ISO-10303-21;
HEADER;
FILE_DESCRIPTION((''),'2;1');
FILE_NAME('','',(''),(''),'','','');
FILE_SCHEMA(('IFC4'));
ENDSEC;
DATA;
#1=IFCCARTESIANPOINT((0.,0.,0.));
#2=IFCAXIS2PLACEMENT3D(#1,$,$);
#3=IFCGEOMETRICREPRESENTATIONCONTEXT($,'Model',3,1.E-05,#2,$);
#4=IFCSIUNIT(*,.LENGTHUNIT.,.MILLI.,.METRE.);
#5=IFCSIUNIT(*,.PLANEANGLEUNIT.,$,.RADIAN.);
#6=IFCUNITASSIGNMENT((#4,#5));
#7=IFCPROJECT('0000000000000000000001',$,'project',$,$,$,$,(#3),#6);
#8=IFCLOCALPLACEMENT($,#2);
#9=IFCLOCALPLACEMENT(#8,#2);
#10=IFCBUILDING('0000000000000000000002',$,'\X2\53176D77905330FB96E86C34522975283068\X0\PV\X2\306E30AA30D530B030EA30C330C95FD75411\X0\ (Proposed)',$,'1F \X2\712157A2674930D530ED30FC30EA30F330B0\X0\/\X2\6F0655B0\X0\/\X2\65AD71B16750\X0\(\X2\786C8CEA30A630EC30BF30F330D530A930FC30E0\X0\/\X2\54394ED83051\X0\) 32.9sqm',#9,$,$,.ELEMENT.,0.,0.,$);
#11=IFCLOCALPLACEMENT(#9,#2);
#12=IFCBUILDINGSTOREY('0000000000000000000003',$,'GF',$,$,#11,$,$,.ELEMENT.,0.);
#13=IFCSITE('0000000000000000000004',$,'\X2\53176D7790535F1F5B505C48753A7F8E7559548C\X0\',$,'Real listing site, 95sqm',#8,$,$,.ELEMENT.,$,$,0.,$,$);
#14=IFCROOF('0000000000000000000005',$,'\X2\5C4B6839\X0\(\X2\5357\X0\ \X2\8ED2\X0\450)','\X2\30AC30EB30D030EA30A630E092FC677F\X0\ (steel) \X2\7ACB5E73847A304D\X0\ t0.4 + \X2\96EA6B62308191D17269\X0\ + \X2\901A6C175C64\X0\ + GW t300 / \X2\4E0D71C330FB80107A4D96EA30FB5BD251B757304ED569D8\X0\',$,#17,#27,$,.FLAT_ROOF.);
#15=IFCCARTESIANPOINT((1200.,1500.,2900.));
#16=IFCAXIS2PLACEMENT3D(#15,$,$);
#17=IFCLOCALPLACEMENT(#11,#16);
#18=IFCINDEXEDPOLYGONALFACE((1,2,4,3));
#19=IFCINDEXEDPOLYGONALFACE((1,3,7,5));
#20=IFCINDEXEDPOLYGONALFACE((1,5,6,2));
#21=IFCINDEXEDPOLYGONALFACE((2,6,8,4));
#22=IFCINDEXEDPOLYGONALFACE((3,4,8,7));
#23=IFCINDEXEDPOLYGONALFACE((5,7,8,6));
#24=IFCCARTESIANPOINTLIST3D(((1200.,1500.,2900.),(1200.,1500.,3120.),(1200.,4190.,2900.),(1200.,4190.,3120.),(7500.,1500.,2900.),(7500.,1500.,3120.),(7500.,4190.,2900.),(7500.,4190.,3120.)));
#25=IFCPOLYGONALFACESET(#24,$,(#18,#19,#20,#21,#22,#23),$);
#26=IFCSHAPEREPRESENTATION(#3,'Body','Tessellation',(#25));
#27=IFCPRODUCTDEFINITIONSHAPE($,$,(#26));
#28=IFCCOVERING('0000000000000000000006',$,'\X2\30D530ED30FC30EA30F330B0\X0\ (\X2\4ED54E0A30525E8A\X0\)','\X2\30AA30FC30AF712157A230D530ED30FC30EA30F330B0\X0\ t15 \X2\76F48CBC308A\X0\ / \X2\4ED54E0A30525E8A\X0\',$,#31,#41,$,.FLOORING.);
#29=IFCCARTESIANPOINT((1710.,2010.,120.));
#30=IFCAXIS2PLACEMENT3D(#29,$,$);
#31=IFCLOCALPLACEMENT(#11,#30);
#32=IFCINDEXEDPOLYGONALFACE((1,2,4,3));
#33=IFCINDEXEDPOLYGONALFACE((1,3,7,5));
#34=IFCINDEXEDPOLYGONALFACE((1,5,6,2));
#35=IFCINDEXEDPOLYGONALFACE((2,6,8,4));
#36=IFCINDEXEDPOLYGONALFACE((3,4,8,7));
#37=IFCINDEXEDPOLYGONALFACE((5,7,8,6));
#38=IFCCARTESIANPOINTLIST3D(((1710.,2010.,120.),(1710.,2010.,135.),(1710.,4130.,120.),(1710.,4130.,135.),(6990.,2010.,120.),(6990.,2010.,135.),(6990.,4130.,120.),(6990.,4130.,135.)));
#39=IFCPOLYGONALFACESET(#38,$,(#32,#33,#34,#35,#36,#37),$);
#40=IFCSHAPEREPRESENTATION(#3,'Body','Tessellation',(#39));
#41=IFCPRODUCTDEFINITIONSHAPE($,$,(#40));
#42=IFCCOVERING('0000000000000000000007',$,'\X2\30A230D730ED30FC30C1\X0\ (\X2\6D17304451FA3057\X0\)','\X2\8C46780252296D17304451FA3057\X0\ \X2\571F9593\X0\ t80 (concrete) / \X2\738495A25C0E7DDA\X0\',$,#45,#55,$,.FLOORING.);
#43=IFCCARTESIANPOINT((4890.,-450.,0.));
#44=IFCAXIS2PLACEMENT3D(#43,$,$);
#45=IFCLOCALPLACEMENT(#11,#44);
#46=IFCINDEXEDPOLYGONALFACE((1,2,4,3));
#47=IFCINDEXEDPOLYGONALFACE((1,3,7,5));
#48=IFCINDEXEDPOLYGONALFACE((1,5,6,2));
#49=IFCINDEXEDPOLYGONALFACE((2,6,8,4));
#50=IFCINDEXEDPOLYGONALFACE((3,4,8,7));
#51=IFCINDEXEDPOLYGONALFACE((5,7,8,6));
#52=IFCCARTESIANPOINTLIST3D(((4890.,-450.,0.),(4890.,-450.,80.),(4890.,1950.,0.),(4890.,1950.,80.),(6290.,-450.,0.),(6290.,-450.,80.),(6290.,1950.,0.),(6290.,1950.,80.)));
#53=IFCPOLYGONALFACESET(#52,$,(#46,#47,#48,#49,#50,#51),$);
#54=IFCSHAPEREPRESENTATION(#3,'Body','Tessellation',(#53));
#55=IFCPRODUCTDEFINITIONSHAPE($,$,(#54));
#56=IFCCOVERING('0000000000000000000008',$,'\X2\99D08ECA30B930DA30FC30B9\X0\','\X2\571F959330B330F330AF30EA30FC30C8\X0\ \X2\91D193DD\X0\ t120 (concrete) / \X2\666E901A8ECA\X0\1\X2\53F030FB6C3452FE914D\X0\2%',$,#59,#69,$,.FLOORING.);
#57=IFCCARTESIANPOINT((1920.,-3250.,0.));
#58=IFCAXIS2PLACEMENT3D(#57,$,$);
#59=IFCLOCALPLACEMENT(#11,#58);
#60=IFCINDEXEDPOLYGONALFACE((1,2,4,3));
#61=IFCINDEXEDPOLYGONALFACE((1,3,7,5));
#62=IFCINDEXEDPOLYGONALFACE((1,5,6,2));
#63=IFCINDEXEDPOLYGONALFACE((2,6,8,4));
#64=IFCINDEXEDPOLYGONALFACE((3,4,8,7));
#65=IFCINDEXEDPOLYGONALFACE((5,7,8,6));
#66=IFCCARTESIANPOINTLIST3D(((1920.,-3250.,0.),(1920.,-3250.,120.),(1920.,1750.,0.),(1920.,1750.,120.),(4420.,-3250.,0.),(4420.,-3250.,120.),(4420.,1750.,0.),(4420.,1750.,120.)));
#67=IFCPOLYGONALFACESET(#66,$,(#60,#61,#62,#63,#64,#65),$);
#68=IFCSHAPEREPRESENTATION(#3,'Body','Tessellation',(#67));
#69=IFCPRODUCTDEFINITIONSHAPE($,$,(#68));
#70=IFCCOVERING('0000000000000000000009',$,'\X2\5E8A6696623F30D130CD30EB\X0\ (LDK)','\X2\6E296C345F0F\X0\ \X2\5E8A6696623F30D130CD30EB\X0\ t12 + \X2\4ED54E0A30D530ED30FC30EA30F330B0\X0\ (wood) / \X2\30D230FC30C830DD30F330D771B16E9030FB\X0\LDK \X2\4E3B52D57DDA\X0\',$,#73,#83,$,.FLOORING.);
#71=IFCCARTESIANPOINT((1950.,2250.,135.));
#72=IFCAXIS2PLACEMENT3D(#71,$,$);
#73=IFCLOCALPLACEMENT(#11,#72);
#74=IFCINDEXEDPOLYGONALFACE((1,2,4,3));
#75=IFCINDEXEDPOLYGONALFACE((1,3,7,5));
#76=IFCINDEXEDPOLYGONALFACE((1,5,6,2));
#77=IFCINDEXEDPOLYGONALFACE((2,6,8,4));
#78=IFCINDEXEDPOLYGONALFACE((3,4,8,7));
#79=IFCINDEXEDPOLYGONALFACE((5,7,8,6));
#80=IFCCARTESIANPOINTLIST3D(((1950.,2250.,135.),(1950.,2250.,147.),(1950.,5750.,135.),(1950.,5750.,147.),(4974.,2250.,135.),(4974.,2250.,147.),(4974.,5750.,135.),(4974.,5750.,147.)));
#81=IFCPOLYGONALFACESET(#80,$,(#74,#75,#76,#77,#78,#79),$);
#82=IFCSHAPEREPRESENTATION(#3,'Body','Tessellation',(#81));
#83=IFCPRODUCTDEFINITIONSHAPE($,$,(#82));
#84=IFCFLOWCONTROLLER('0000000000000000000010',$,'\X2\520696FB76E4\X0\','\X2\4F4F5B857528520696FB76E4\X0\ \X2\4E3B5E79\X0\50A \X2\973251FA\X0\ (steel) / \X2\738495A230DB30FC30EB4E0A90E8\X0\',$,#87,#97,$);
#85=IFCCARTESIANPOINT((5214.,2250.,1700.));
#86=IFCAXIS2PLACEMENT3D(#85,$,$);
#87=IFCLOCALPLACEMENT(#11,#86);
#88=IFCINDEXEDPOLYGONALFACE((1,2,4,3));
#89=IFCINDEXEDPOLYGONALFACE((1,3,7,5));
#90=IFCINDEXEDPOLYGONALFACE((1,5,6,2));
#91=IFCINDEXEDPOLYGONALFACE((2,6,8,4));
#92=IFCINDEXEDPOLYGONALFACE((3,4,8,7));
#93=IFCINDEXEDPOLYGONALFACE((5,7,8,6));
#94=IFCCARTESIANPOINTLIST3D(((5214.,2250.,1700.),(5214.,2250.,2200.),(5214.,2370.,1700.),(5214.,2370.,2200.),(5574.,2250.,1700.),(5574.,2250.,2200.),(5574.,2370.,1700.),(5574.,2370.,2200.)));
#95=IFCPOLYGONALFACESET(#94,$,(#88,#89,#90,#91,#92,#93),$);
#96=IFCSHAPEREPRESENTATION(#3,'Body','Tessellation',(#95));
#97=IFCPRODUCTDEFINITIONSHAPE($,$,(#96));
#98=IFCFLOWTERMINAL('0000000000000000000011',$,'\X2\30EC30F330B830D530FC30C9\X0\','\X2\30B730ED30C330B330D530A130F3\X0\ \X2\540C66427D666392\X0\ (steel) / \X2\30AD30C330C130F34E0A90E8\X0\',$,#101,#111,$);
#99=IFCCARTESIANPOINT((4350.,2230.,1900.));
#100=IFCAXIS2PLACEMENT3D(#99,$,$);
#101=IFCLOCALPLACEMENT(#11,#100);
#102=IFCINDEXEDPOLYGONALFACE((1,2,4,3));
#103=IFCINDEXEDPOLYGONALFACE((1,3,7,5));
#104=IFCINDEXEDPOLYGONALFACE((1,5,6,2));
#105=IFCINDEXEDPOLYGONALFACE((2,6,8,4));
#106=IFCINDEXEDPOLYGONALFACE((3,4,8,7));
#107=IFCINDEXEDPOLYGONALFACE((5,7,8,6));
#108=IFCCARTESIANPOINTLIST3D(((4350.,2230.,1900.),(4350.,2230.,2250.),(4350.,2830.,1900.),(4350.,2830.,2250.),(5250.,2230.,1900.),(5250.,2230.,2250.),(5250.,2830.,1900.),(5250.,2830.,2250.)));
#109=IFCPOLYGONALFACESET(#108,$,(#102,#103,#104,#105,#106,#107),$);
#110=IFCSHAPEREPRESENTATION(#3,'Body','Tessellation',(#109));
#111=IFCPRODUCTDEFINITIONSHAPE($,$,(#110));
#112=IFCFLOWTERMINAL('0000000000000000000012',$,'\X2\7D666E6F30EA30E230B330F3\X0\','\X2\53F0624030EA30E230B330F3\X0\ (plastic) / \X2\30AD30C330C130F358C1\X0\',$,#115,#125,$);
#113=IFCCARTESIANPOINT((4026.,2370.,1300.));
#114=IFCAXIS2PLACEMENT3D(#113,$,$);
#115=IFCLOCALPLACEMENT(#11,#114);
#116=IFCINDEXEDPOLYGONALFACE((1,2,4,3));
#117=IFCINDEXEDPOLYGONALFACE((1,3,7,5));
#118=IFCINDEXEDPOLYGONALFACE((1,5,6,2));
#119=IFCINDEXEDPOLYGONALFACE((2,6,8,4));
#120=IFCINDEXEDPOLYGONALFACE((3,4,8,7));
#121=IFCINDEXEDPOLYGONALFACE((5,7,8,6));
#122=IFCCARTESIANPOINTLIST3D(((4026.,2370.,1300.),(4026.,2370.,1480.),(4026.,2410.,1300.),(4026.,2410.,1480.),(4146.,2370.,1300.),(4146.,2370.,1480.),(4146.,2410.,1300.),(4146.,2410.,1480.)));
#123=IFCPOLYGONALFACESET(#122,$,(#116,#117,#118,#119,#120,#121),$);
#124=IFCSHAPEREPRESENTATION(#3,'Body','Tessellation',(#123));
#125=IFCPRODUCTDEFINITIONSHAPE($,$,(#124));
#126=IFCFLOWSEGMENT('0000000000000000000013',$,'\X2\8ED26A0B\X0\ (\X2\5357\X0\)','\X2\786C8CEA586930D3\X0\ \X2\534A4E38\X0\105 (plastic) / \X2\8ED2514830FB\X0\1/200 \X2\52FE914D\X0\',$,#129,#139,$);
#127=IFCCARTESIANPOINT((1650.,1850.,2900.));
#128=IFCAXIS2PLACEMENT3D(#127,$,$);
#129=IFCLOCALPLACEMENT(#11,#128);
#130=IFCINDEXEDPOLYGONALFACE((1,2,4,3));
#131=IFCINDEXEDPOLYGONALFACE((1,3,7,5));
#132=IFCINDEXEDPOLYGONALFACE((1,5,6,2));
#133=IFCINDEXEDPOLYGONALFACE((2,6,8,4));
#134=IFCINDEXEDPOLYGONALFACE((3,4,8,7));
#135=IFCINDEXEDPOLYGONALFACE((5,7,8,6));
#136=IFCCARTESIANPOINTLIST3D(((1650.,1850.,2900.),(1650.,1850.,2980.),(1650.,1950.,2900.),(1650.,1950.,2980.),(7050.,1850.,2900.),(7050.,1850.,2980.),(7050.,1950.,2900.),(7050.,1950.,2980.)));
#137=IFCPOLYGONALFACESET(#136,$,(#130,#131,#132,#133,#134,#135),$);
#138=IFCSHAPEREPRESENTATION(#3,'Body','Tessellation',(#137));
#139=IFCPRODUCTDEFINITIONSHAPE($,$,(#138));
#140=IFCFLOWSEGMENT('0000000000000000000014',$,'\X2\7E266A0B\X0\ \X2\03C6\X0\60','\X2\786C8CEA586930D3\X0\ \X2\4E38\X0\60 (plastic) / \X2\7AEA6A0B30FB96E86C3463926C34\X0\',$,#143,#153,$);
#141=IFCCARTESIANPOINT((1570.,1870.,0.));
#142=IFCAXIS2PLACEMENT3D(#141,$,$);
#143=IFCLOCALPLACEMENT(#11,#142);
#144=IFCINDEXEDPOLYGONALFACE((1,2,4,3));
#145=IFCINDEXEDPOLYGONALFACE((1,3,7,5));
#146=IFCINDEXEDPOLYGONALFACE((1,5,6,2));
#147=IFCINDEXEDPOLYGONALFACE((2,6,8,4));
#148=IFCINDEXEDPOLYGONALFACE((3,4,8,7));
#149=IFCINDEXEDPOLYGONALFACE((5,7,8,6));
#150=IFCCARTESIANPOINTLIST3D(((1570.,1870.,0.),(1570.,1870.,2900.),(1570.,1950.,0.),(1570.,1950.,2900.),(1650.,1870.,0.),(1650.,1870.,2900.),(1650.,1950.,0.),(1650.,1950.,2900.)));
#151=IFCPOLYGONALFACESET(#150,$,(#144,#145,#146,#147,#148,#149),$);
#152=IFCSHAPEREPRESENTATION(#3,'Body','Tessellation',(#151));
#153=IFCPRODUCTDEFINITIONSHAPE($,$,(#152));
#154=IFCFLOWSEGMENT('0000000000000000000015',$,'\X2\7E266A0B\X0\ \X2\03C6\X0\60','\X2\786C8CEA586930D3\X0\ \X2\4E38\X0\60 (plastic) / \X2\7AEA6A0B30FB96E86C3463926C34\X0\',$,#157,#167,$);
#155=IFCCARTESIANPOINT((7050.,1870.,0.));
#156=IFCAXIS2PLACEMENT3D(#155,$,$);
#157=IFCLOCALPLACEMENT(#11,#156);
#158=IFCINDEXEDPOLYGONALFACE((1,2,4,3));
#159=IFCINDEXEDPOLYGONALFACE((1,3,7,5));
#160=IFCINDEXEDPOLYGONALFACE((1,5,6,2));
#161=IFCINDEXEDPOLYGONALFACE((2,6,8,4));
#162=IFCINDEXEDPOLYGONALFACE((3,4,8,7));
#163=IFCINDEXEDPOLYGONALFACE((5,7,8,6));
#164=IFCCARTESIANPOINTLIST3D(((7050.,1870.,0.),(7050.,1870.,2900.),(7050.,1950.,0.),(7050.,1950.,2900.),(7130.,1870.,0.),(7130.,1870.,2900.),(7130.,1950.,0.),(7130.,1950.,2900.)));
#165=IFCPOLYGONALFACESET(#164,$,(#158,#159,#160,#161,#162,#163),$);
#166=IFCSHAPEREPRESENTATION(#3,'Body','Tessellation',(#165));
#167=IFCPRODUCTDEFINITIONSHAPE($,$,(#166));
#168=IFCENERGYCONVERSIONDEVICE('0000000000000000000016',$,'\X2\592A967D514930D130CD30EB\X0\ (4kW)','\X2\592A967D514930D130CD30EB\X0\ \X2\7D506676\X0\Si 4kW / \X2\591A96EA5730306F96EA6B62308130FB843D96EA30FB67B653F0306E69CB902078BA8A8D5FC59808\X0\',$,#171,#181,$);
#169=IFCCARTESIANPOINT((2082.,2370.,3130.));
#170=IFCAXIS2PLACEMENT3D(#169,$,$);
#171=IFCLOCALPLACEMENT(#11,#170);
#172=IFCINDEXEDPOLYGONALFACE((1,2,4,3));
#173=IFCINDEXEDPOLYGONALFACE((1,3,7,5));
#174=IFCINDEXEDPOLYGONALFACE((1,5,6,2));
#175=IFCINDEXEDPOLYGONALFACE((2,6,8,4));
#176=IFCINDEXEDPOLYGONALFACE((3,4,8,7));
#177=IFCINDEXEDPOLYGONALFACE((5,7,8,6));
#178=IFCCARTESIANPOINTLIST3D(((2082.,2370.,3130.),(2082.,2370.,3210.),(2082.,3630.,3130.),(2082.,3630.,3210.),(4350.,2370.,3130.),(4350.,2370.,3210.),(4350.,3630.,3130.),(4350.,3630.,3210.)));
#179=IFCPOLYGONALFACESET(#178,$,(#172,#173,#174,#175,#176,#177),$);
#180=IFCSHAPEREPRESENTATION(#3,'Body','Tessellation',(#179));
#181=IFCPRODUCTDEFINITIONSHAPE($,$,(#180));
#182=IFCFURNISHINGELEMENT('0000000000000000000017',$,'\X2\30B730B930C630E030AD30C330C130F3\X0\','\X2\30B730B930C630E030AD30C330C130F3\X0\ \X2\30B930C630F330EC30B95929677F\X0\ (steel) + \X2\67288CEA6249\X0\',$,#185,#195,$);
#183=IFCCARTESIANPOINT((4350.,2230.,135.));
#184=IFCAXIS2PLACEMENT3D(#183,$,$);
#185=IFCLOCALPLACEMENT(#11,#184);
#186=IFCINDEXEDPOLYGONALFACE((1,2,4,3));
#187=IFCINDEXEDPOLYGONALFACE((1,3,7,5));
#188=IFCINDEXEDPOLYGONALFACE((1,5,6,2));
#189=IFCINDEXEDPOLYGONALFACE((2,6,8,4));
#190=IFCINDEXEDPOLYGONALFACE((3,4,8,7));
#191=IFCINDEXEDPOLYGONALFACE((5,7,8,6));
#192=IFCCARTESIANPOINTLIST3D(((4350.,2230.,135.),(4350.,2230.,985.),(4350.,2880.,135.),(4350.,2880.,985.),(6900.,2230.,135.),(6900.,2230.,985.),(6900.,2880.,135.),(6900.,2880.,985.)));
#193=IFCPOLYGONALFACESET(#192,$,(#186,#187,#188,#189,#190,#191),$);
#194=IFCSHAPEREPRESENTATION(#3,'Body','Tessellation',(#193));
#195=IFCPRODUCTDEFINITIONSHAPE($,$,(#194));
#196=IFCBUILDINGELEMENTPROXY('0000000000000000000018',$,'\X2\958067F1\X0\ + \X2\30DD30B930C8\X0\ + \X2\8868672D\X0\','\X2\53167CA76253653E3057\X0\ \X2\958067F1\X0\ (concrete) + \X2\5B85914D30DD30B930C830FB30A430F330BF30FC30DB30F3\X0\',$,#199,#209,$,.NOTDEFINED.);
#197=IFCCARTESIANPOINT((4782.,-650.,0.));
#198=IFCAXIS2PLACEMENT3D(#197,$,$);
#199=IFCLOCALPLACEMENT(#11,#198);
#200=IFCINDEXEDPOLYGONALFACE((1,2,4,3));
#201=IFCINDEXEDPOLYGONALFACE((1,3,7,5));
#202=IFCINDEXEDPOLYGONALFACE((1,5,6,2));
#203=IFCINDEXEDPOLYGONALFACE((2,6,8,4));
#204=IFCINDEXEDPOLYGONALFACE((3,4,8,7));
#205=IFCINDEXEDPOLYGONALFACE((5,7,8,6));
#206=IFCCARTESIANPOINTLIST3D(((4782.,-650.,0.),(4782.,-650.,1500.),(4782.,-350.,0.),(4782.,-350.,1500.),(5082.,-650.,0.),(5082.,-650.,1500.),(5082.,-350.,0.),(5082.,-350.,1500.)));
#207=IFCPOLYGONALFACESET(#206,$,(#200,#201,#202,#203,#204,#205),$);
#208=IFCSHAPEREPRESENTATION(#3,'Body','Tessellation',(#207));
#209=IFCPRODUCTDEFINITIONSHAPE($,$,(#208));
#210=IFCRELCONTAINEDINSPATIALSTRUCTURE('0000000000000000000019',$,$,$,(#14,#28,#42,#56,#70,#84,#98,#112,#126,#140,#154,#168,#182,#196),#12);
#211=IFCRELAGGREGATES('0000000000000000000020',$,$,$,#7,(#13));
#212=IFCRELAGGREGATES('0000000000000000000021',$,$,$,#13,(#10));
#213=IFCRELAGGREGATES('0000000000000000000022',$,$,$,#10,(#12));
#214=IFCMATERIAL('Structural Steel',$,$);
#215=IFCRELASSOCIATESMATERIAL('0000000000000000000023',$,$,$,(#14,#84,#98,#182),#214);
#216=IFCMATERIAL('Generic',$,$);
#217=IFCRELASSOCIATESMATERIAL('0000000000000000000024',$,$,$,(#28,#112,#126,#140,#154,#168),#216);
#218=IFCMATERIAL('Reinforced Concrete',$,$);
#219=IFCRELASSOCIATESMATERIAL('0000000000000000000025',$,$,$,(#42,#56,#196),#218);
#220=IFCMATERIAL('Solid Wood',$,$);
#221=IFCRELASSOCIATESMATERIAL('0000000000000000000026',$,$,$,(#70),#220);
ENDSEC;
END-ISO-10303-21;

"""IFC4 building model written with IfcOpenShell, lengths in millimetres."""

from ifc_helpers import new_model, si_unit, frame, frame_2d, origin, place, context, project, spatial, rectangle, extrude, material, element, save


model = new_model("IFC4")

# Units and contexts
model_context = context("Model", 3, precision=1e-05, world=origin())
ifc_project = project(units=[si_unit("LENGTHUNIT", "METRE", prefix="MILLI"), si_unit("PLANEANGLEUNIT", "RADIAN")], contexts=[model_context])

# Site, building, storey
site_placement = place(None, origin())
site = spatial("IfcSite", under=ifc_project, at=site_placement, Name="北海道弟子屈町美留和", ObjectType="Real listing site, 95sqm", CompositionType="ELEMENT", RefElevation=0.0)
building_placement = place(site_placement, origin())
building = spatial("IfcBuilding", under=site, at=building_placement, Name="北海道・雨水利用とPVのオフグリッド志向 (Proposed)", ObjectType="1F 無垢杉フローリング/漆喰/断熱材(硬質ウレタンフォーム/吹付け) 32.9sqm", CompositionType="ELEMENT", ElevationOfRefHeight=0.0, ElevationOfTerrain=0.0)
storey_placement = place(building_placement, origin())
storey = spatial("IfcBuildingStorey", under=building, at=storey_placement, Name="GF", CompositionType="ELEMENT", Elevation=0.0)

# Shared definitions
ifc_material_1 = material(Name="Solid Wood")

# Shared definitions
ifc_material_2 = material(Name="Reinforced Concrete")

# Roof
ifc_material_3 = material(Name="Structural Steel")
roof_placement = place(storey_placement, frame((1200.0, 1500.0, 2900.0)))
element("IfcRoof", 1, at=roof_placement, inside=storey, material=ifc_material_3, Name="屋根(南 軒450)", Description="ガルバリウム鋼板 (steel) 立平葺き t0.4 + 雪止め金物 + 通気層 + GW t300 / 不燃・耐積雪・寒冷地仕様", PredefinedType="FLAT_ROOF", context=model_context, shape_type="SweptSolid", body=[
    extrude(rectangle(XDim=6300.0, YDim=2690.0, at=frame_2d((3150.0, 1345.0))), frame((1200.0, 1500.0, 2900.0)), (0.0, 0.0, 1.0), 220.0),
])

# Coverings
ifc_material_4 = material(Name="Generic")
covering_1_placement = place(storey_placement, frame((1710.0, 2010.0, 120.0)))
element("IfcCovering", 2, at=covering_1_placement, inside=storey, material=ifc_material_4, Name="フローリング (仕上げ床)", Description="オーク無垢フローリング t15 直貼り / 仕上げ床", PredefinedType="FLOORING", context=model_context, shape_type="SweptSolid", body=[
    extrude(rectangle(XDim=5280.0, YDim=2120.0, at=frame_2d((2640.0, 1060.0))), frame((1710.0, 2010.0, 120.0)), (0.0, 0.0, 1.0), 15.0),
])
covering_2_placement = place(storey_placement, frame((4890.0, -450.0, 0.0)))
element("IfcCovering", 3, at=covering_2_placement, inside=storey, material=ifc_material_2, Name="アプローチ (洗い出し)", Description="豆砂利洗い出し 土間 t80 (concrete) / 玄関導線", PredefinedType="FLOORING", context=model_context, shape_type="SweptSolid", body=[
    extrude(rectangle(XDim=1400.0, YDim=2400.0, at=frame_2d((700.0, 1200.0))), frame((4890.0, -450.0, 0.0)), (0.0, 0.0, 1.0), 80.0),
])
covering_3_placement = place(storey_placement, frame((1920.0, -3250.0, 0.0)))
element("IfcCovering", 4, at=covering_3_placement, inside=storey, material=ifc_material_2, Name="駐車スペース", Description="土間コンクリート 金鏝 t120 (concrete) / 普通車1台・水勾配2%", PredefinedType="FLOORING", context=model_context, shape_type="SweptSolid", body=[
    extrude(rectangle(XDim=2500.0, YDim=5000.0, at=frame_2d((1250.0, 2500.0))), frame((1920.0, -3250.0, 0.0)), (0.0, 0.0, 1.0), 120.0),
])
covering_4_placement = place(storey_placement, frame((1950.0, 2250.0, 135.0)))
element("IfcCovering", 5, at=covering_4_placement, inside=storey, material=ifc_material_1, Name="床暖房パネル (LDK)", Description="温水式 床暖房パネル t12 + 仕上フローリング (wood) / ヒートポンプ熱源・LDK 主動線", PredefinedType="FLOORING", context=model_context, shape_type="SweptSolid", body=[
    extrude(rectangle(XDim=3024.0, YDim=3500.0, at=frame_2d((1512.0, 1750.0))), frame((1950.0, 2250.0, 135.0)), (0.0, 0.0, 1.0), 12.0),
])

# Flow controller
flow_controller_placement = place(storey_placement, frame((5214.0, 2250.0, 1700.0)))
element("IfcFlowController", 6, at=flow_controller_placement, inside=storey, material=ifc_material_3, Name="分電盤", Description="住宅用分電盤 主幹50A 露出 (steel) / 玄関ホール上部", context=model_context, shape_type="SweptSolid", body=[
    extrude(rectangle(XDim=360.0, YDim=120.0, at=frame_2d((180.0, 60.0))), frame((5214.0, 2250.0, 1700.0)), (0.0, 0.0, 1.0), 500.0),
])

# Flow terminals
flow_terminal_1_placement = place(storey_placement, frame((4350.0, 2230.0, 1900.0)))
element("IfcFlowTerminal", 7, at=flow_terminal_1_placement, inside=storey, material=ifc_material_3, Name="レンジフード", Description="シロッコファン 同時給排 (steel) / キッチン上部", context=model_context, shape_type="SweptSolid", body=[
    extrude(rectangle(XDim=900.0, YDim=600.0, at=frame_2d((450.0, 300.0))), frame((4350.0, 2230.0, 1900.0)), (0.0, 0.0, 1.0), 350.0),
])
flow_terminal_2_placement = place(storey_placement, frame((4026.0, 2370.0, 1300.0)))
element("IfcFlowTerminal", 8, at=flow_terminal_2_placement, inside=storey, material=ifc_material_4, Name="給湯リモコン", Description="台所リモコン (plastic) / キッチン壁", context=model_context, shape_type="SweptSolid", body=[
    extrude(rectangle(XDim=120.0, YDim=40.0, at=frame_2d((60.0, 20.0))), frame((4026.0, 2370.0, 1300.0)), (0.0, 0.0, 1.0), 180.0),
])

# Flow segments
flow_segment_1_placement = place(storey_placement, frame((1650.0, 1850.0, 2900.0)))
element("IfcFlowSegment", 9, at=flow_segment_1_placement, inside=storey, material=ifc_material_4, Name="軒樋 (南)", Description="硬質塩ビ 半丸105 (plastic) / 軒先・1/200 勾配", context=model_context, shape_type="SweptSolid", body=[
    extrude(rectangle(XDim=5400.0, YDim=100.0, at=frame_2d((2700.0, 50.0))), frame((1650.0, 1850.0, 2900.0)), (0.0, 0.0, 1.0), 80.0),
])
flow_segment_2_placement = place(storey_placement, frame((1570.0, 1870.0, 0.0)))
element("IfcFlowSegment", 10, at=flow_segment_2_placement, inside=storey, material=ifc_material_4, Name="縦樋 φ60", Description="硬質塩ビ 丸60 (plastic) / 竪樋・雨水排水", context=model_context, shape_type="SweptSolid", body=[
    extrude(rectangle(XDim=80.0, YDim=80.0, at=frame_2d((40.0, 40.0))), frame((1570.0, 1870.0, 0.0)), (0.0, 0.0, 1.0), 2900.0),
])
flow_segment_3_placement = place(storey_placement, frame((7050.0, 1870.0, 0.0)))
element("IfcFlowSegment", 11, at=flow_segment_3_placement, inside=storey, material=ifc_material_4, Name="縦樋 φ60", Description="硬質塩ビ 丸60 (plastic) / 竪樋・雨水排水", context=model_context, shape_type="SweptSolid", body=[
    extrude(rectangle(XDim=80.0, YDim=80.0, at=frame_2d((40.0, 40.0))), frame((7050.0, 1870.0, 0.0)), (0.0, 0.0, 1.0), 2900.0),
])

# Energy conversion device
energy_conversion_device_placement = place(storey_placement, frame((2082.0, 2370.0, 3130.0)))
element("IfcEnergyConversionDevice", 12, at=energy_conversion_device_placement, inside=storey, material=ifc_material_4, Name="太陽光パネル (4kW)", Description="太陽光パネル 結晶Si 4kW / 多雪地は雪止め・落雪・架台の構造確認必須", context=model_context, shape_type="SweptSolid", body=[
    extrude(rectangle(XDim=2268.0, YDim=1260.0, at=frame_2d((1134.0, 630.0))), frame((2082.0, 2370.0, 3130.0)), (0.0, 0.0, 1.0), 80.0),
])

# Furnishing element
furnishing_placement = place(storey_placement, frame((4350.0, 2230.0, 135.0)))
element("IfcFurnishingElement", 13, at=furnishing_placement, inside=storey, material=ifc_material_3, Name="システムキッチン", Description="システムキッチン ステンレス天板 (steel) + 木質扉", context=model_context, shape_type="SweptSolid", body=[
    extrude(rectangle(XDim=2550.0, YDim=650.0, at=frame_2d((1275.0, 325.0))), frame((4350.0, 2230.0, 135.0)), (0.0, 0.0, 1.0), 850.0),
])

# Building element proxy
proxy_placement = place(storey_placement, frame((4782.0, -650.0, 0.0)))
element("IfcBuildingElementProxy", 14, at=proxy_placement, inside=storey, material=ifc_material_2, Name="門柱 + ポスト + 表札", Description="化粧打放し 門柱 (concrete) + 宅配ポスト・インターホン", PredefinedType="NOTDEFINED", context=model_context, shape_type="SweptSolid", body=[
    extrude(rectangle(XDim=300.0, YDim=300.0, at=frame_2d((150.0, 150.0))), frame((4782.0, -650.0, 0.0)), (0.0, 0.0, 1.0), 1500.0),
])

save(model, "model.ifc")
